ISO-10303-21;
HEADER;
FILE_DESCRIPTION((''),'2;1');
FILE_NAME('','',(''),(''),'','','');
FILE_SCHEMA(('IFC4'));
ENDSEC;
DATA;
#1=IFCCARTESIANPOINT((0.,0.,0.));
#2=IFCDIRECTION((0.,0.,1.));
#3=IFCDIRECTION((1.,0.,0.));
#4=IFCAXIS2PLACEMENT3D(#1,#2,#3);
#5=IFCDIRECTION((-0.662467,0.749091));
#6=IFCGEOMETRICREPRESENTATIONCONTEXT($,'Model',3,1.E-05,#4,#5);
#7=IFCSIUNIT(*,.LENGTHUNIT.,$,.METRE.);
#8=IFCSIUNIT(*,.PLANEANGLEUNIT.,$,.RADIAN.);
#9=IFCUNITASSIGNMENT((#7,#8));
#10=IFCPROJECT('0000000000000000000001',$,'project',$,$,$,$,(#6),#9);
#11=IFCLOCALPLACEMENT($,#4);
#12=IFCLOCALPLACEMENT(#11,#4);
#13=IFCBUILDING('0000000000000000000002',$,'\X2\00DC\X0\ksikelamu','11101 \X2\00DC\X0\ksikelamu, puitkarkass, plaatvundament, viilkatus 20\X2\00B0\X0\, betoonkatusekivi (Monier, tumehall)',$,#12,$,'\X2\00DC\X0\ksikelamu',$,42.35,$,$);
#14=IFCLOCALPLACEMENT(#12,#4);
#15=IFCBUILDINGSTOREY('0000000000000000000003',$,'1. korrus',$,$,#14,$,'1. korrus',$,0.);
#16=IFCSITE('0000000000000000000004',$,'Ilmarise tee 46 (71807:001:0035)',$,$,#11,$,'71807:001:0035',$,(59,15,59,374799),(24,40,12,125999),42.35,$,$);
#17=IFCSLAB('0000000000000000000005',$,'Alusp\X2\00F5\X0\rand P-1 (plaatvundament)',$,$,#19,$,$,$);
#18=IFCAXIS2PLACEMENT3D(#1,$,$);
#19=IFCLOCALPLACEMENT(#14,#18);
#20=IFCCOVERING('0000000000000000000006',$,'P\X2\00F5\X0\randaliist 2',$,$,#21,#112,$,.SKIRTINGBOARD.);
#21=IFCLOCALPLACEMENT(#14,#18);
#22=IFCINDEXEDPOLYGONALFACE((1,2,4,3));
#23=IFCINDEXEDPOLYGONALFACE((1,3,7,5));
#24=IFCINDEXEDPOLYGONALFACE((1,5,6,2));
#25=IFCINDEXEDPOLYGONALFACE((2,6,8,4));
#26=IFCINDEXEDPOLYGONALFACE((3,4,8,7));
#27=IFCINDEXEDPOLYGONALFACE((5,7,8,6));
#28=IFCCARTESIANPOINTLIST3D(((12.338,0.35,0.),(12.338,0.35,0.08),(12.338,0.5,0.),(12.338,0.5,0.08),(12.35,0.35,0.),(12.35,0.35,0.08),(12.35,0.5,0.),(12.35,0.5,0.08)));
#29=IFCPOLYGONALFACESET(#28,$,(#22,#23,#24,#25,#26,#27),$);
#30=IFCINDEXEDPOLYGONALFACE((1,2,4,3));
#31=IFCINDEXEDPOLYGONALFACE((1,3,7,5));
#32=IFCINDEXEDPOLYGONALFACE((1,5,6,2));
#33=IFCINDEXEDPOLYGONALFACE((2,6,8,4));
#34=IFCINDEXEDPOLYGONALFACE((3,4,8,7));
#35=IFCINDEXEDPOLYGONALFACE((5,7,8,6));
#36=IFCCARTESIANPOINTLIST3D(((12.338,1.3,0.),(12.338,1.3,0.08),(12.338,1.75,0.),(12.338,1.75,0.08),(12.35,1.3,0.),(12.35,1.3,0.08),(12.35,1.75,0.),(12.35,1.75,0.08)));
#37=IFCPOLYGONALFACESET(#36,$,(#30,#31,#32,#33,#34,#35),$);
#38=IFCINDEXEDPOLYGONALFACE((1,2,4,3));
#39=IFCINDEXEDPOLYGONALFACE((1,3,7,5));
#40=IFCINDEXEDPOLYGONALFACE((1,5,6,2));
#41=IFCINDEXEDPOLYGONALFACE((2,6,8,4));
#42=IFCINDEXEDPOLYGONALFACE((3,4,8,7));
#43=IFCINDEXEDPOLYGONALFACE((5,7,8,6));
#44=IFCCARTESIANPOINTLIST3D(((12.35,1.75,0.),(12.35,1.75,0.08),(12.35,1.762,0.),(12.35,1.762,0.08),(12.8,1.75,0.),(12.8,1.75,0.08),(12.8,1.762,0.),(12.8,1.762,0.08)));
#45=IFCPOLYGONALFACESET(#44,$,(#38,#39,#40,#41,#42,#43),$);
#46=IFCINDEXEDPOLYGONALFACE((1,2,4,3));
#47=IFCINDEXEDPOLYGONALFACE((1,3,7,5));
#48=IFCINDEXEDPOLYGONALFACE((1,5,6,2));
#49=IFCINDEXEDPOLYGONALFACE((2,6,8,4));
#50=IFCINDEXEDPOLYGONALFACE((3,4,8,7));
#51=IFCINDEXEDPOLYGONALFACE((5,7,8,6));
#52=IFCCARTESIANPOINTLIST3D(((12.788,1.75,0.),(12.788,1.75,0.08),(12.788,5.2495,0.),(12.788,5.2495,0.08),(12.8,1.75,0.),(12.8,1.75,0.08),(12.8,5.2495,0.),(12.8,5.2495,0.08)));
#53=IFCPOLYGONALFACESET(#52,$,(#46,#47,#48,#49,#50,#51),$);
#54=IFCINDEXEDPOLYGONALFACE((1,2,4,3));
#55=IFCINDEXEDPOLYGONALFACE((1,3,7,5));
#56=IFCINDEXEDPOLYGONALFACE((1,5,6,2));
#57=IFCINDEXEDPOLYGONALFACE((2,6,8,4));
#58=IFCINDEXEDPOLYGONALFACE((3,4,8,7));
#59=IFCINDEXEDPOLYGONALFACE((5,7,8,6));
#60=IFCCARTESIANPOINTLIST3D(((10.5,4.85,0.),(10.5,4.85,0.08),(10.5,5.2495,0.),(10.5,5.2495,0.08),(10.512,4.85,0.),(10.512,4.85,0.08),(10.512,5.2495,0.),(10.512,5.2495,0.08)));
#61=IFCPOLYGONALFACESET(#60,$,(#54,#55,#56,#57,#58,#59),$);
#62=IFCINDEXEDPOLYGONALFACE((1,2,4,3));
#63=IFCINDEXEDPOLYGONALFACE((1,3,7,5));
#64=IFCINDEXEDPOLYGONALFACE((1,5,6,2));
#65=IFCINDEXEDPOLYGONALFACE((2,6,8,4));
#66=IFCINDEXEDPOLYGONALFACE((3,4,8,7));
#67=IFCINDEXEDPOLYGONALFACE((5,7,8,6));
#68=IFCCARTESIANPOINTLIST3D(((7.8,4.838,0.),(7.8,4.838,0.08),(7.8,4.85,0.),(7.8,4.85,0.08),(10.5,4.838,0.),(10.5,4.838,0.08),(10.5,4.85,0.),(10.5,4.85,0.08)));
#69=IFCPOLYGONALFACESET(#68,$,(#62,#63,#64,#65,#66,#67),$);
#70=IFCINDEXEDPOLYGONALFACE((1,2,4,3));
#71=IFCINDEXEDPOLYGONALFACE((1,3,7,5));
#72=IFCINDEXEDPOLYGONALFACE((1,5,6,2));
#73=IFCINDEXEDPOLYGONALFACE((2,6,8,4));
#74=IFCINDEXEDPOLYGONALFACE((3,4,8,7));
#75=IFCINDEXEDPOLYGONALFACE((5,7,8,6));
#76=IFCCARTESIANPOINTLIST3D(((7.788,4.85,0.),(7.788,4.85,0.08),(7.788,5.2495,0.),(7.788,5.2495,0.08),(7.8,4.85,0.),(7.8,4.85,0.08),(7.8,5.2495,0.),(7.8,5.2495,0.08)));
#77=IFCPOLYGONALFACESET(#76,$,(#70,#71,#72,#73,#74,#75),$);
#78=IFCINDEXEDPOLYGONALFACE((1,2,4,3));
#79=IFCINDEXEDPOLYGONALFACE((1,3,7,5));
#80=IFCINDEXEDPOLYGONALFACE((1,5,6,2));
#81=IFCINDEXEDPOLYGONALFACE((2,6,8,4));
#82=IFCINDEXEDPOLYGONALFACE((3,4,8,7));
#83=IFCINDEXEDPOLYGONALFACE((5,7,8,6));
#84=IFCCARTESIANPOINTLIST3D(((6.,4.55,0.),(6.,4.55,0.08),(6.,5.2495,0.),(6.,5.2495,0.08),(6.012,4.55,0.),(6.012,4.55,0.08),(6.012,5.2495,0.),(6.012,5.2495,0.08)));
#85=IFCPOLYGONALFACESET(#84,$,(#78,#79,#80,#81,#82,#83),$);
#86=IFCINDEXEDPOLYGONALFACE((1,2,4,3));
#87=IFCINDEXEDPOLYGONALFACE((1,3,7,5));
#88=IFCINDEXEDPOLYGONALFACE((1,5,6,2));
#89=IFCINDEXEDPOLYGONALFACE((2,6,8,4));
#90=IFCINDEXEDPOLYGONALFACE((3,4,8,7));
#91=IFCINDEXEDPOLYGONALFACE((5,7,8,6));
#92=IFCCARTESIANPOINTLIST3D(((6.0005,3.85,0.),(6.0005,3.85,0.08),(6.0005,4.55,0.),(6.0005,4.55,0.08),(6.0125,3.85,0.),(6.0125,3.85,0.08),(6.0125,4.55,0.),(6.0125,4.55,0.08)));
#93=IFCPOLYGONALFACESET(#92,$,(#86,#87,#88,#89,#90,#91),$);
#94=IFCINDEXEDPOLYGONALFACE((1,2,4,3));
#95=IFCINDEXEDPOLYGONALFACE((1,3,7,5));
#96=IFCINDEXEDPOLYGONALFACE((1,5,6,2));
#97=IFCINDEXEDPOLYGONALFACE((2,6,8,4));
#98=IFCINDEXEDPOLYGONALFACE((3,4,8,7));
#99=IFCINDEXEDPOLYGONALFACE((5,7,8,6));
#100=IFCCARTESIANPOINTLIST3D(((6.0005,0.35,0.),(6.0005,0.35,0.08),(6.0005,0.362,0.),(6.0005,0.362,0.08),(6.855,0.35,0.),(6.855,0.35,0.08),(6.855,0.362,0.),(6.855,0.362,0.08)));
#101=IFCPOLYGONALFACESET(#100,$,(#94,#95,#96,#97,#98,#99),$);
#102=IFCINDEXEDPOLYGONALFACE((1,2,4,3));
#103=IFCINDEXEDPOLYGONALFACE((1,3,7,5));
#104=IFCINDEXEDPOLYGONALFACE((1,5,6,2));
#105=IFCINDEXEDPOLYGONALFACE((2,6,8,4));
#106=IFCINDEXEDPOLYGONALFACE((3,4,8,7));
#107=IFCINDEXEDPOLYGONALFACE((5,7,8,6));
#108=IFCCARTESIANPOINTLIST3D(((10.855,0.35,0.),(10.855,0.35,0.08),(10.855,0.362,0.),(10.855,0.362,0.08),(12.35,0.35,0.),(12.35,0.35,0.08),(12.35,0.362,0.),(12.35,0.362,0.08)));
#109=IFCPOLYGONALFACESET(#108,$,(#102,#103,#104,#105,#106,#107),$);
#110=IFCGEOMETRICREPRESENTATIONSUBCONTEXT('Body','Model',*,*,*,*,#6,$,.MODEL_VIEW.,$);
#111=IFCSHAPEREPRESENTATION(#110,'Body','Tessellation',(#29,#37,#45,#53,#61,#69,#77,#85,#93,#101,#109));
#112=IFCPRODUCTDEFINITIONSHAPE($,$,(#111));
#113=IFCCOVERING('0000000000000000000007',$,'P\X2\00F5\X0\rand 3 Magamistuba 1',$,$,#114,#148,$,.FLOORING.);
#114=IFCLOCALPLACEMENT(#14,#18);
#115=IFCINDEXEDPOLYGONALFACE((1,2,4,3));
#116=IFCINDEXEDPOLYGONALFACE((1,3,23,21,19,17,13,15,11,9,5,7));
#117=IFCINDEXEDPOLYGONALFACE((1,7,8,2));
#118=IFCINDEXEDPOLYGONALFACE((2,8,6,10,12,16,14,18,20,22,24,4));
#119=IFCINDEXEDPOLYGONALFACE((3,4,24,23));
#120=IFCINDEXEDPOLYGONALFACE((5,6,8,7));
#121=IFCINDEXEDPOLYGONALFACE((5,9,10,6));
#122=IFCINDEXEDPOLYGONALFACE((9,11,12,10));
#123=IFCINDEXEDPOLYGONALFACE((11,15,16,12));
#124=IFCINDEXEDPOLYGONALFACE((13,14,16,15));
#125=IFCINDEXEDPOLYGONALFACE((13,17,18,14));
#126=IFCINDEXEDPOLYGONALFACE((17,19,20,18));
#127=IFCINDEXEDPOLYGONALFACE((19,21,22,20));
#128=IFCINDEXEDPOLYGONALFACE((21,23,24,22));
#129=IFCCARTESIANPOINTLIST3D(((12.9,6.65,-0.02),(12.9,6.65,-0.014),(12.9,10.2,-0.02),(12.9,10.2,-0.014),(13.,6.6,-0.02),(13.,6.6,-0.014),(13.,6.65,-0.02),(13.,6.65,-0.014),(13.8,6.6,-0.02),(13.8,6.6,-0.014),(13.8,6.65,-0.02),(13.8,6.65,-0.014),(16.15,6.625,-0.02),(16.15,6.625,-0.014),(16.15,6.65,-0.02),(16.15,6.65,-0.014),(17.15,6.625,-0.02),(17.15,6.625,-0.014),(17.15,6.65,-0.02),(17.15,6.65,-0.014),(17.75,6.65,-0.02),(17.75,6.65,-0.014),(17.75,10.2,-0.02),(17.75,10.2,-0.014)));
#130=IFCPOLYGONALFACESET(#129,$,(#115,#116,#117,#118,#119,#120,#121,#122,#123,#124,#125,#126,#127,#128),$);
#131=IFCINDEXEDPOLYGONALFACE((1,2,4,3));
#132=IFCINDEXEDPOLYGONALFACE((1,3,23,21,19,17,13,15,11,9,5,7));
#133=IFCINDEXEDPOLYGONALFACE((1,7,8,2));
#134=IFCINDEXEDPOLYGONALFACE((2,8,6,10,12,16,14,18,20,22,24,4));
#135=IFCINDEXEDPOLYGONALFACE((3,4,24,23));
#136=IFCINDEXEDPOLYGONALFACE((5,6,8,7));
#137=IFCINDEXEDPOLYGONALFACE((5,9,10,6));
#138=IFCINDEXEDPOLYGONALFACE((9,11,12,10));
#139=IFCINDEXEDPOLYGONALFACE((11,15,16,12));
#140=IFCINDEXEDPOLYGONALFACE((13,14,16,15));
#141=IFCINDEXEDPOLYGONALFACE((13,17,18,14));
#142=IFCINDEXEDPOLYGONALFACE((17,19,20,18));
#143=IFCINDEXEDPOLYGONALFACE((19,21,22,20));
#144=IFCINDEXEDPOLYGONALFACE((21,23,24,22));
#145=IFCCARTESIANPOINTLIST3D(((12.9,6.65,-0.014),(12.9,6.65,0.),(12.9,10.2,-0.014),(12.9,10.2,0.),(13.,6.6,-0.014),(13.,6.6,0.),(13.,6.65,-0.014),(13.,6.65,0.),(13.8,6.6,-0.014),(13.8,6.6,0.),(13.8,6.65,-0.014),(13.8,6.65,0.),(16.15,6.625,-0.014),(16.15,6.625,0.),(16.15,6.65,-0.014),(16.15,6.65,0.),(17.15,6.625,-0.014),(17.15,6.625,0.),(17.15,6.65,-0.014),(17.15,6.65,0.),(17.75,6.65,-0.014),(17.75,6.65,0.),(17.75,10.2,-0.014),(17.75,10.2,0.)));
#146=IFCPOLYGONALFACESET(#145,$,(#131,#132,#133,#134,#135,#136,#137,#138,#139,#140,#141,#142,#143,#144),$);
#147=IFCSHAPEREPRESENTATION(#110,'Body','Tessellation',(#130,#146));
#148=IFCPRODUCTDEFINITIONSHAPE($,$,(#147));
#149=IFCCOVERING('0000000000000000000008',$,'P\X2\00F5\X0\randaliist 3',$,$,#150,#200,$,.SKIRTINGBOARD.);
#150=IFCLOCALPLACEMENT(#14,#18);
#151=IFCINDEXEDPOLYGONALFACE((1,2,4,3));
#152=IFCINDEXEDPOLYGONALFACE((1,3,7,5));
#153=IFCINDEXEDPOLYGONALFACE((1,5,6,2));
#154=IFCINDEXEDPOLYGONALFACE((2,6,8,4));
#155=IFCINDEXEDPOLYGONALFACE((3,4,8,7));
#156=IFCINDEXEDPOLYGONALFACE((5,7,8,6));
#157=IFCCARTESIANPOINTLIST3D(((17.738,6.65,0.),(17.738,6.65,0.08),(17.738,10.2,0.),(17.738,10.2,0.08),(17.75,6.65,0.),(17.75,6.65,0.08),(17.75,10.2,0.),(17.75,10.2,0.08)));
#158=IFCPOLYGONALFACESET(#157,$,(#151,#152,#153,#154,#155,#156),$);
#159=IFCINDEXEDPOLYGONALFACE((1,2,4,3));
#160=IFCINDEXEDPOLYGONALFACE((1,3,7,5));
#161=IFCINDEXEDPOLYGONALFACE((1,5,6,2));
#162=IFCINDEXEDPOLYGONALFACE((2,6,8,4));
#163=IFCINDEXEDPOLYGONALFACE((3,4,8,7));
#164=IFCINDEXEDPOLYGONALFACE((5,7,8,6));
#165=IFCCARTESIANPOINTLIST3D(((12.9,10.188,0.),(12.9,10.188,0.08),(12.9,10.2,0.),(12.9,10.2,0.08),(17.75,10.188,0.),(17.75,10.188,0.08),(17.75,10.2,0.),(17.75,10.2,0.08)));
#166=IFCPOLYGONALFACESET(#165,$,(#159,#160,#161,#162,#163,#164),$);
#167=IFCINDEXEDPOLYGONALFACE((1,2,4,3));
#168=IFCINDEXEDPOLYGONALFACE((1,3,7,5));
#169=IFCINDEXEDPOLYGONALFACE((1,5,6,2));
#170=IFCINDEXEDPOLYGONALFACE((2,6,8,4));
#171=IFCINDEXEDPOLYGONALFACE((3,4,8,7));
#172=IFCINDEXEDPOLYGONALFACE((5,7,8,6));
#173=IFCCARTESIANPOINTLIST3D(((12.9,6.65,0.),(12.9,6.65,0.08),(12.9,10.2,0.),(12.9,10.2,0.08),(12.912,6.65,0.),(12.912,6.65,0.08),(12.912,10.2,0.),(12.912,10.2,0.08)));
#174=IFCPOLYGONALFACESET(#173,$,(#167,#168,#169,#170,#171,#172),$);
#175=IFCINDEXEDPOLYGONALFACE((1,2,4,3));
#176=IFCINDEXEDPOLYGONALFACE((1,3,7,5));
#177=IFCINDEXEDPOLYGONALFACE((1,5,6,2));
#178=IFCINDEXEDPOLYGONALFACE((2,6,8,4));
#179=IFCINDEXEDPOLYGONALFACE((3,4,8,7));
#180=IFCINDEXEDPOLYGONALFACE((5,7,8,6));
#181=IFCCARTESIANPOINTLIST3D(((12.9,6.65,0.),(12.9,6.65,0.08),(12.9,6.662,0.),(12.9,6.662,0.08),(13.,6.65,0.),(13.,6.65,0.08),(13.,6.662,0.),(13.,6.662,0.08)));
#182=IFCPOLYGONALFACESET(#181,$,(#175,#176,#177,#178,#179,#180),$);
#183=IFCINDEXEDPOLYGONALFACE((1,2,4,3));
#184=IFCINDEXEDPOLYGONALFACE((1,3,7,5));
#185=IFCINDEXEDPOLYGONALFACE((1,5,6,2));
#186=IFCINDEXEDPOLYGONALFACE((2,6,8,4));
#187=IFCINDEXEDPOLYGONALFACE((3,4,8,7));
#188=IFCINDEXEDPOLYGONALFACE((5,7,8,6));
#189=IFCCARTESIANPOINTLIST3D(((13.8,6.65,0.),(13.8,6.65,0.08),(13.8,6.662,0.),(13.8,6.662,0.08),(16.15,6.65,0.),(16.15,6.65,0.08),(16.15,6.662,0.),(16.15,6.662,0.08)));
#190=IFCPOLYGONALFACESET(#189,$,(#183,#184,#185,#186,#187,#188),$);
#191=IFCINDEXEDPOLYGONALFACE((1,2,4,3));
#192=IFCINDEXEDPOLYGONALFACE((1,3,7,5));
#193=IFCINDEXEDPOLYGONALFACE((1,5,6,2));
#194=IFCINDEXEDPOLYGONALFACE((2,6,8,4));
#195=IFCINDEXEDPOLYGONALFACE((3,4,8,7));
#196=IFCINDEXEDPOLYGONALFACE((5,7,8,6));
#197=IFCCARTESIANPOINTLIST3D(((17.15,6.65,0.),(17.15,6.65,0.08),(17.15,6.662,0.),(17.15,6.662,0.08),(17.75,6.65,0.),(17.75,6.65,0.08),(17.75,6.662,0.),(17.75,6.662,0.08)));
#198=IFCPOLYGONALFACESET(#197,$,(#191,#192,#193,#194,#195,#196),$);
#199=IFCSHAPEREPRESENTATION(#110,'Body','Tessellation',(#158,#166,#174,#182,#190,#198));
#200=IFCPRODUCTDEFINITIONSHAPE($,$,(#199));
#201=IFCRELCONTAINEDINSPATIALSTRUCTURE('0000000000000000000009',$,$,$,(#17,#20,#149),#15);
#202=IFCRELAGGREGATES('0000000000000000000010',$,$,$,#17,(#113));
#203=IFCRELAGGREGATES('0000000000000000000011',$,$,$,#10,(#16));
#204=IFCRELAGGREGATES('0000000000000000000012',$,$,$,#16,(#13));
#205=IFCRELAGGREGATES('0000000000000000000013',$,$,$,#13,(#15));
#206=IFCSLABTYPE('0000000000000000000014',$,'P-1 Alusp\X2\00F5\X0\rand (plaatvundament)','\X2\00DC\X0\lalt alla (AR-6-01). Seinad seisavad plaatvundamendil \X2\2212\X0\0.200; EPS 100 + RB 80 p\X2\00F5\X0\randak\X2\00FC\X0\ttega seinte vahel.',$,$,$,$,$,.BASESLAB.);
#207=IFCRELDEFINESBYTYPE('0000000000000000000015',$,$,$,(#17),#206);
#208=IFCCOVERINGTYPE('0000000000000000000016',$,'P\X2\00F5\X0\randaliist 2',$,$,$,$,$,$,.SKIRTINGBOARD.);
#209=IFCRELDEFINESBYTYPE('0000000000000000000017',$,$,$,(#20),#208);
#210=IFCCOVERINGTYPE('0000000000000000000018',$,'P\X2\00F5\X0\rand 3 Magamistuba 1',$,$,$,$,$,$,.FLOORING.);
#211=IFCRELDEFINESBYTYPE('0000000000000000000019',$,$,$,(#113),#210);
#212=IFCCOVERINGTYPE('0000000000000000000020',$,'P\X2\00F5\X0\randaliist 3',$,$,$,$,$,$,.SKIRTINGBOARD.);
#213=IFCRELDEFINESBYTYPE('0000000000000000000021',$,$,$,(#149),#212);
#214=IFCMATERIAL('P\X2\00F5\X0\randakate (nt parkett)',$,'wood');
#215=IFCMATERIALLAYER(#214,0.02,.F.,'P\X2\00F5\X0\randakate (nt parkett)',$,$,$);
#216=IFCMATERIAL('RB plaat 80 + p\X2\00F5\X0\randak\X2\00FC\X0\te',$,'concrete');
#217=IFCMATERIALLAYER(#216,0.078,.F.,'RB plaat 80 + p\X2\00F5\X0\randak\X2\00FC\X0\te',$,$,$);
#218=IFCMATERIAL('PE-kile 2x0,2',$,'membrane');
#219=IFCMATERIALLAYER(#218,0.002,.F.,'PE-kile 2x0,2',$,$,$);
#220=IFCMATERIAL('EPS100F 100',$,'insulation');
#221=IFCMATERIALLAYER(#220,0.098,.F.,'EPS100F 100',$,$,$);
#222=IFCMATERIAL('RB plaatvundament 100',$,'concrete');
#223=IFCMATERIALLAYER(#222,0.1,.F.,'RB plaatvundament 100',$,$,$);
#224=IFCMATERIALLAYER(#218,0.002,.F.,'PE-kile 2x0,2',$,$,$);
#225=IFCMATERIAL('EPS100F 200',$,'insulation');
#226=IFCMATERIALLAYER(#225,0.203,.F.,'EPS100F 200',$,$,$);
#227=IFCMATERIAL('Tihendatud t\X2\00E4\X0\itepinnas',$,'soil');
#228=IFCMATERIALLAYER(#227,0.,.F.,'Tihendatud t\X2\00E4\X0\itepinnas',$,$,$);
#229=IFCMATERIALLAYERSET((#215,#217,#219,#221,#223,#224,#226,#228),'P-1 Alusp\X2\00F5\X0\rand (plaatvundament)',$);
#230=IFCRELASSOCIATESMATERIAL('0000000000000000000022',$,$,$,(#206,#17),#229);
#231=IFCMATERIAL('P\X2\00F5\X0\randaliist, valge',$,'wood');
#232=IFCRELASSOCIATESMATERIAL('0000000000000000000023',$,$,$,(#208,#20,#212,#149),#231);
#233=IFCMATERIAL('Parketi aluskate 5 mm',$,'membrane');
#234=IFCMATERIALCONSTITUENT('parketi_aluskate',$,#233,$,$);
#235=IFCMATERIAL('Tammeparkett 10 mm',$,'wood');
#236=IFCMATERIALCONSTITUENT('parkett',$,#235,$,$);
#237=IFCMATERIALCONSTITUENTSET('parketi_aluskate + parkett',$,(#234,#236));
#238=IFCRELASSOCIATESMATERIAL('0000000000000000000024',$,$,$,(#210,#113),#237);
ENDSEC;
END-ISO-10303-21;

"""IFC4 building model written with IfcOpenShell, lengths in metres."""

from ifc_helpers import new_model, si_unit, direction, frame, origin_with_axes, place, context, subcontext, project, spatial, indexed_curve, outline, extrude, material, layer, layer_set, layer_usage, constituent, constituent_set, type_object, element, aggregate, save


model = new_model("IFC4")

# Units and contexts
model_context = context("Model", 3, precision=1e-05, world=origin_with_axes(), true_north=direction((-0.662467, 0.749091)))
body_context = subcontext(model_context, "Body", "Model", "MODEL_VIEW")
ifc_project = project(units=[si_unit("LENGTHUNIT", "METRE"), si_unit("PLANEANGLEUNIT", "RADIAN")], contexts=[model_context])

# Site, building, storey
site_placement = place(None, origin_with_axes())
site = spatial("IfcSite", under=ifc_project, at=site_placement, Name="Ilmarise tee 46 (71807:001:0035)", LongName="71807:001:0035", RefLatitude=(59, 15, 59, 374799), RefLongitude=(24, 40, 12, 125999), RefElevation=42.35)
building_placement = place(site_placement, origin_with_axes())
building = spatial("IfcBuilding", under=site, at=building_placement, Name="Üksikelamu", Description="11101 Üksikelamu, puitkarkass, plaatvundament, viilkatus 20°, betoonkatusekivi (Monier, tumehall)", LongName="Üksikelamu", ElevationOfRefHeight=42.35)
storey_placement = place(building_placement, origin_with_axes())
storey = spatial("IfcBuildingStorey", under=building, at=storey_placement, Name="1. korrus", LongName="1. korrus", Elevation=0.0)

# Slab
ifc_material_1 = material(Name="Põrandakate (nt parkett)", Category="wood")
ifc_layer_1 = layer(ifc_material_1, 0.02, ventilated=False, Name="Põrandakate (nt parkett)")
ifc_material_2 = material(Name="RB plaat 80 + põrandaküte", Category="concrete")
ifc_layer_2 = layer(ifc_material_2, 0.078, ventilated=False, Name="RB plaat 80 + põrandaküte")
ifc_material_3 = material(Name="PE-kile 2x0,2", Category="membrane")
ifc_layer_3 = layer(ifc_material_3, 0.002, ventilated=False, Name="PE-kile 2x0,2")
ifc_material_4 = material(Name="EPS100F 100", Category="insulation")
ifc_layer_4 = layer(ifc_material_4, 0.098, ventilated=False, Name="EPS100F 100")
ifc_material_5 = material(Name="RB plaatvundament 100", Category="concrete")
ifc_layer_5 = layer(ifc_material_5, 0.1, ventilated=False, Name="RB plaatvundament 100")
ifc_layer_6 = layer(ifc_material_3, 0.002, ventilated=False, Name="PE-kile 2x0,2")
ifc_material_6 = material(Name="EPS100F 200", Category="insulation")
ifc_layer_7 = layer(ifc_material_6, 0.203, ventilated=False, Name="EPS100F 200")
ifc_material_7 = material(Name="Tihendatud täitepinnas", Category="soil")
ifc_layer_8 = layer(ifc_material_7, 0.0, ventilated=False, Name="Tihendatud täitepinnas")
ifc_layer_set_1 = layer_set([ifc_layer_1, ifc_layer_2, ifc_layer_3, ifc_layer_4, ifc_layer_5, ifc_layer_6, ifc_layer_7, ifc_layer_8], Name="P-1 Aluspõrand (plaatvundament)")
ifc_layer_usage_1 = layer_usage(ifc_layer_set_1, "AXIS3", "NEGATIVE", 0.0)
slab_type = type_object("IfcSlabType", Name="P-1 Aluspõrand (plaatvundament)", Description="Ülalt alla (AR-6-01). Seinad seisavad plaatvundamendil −0.200; EPS 100 + RB 80 põrandaküttega seinte vahel.", PredefinedType="BASESLAB", material=ifc_layer_set_1)
slab_placement = place(storey_placement, origin_with_axes())
slab = element("IfcSlab", 1, at=slab_placement, inside=storey, type_object=slab_type, material=ifc_layer_usage_1, Name="Aluspõrand P-1 (plaatvundament)")
ifc_material_8 = material(Name="Parketi aluskate 5 mm", Category="membrane")

# Coverings
ifc_material_9 = material(Name="Põrandaliist, valge", Category="wood")
covering_type_1 = type_object("IfcCoveringType", Name="Põrandaliist 2", PredefinedType="SKIRTINGBOARD", material=ifc_material_9)
covering_1_placement = place(storey_placement, origin_with_axes())
element("IfcCovering", 2, at=covering_1_placement, inside=storey, type_object=covering_type_1, material=ifc_material_9, Name="Põrandaliist 2", PredefinedType="SKIRTINGBOARD", context=body_context, shape_type="SweptSolid", body=[
    extrude(outline(indexed_curve([(12.35, 0.35), (12.338, 0.35), (12.338, 0.5), (12.35, 0.5), (12.35, 0.35)], self_intersect=False)), origin_with_axes(), (0.0, 0.0, 1.0), 0.08),
    extrude(outline(indexed_curve([(12.338, 1.75), (12.35, 1.75), (12.35, 1.3), (12.338, 1.3), (12.338, 1.75)], self_intersect=False)), origin_with_axes(), (0.0, 0.0, 1.0), 0.08),
    extrude(outline(indexed_curve([(12.35, 1.762), (12.8, 1.762), (12.8, 1.75), (12.35, 1.75), (12.35, 1.762)], self_intersect=False)), origin_with_axes(), (0.0, 0.0, 1.0), 0.08),
    extrude(outline(indexed_curve([(12.788, 1.75), (12.788, 5.2495), (12.8, 5.2495), (12.8, 1.75), (12.788, 1.75)], self_intersect=False)), origin_with_axes(), (0.0, 0.0, 1.0), 0.08),
    extrude(outline(indexed_curve([(10.512, 5.2495), (10.512, 4.85), (10.5, 4.85), (10.5, 5.2495), (10.512, 5.2495)], self_intersect=False)), origin_with_axes(), (0.0, 0.0, 1.0), 0.08),
    extrude(outline(indexed_curve([(10.5, 4.838), (7.8, 4.838), (7.8, 4.85), (10.5, 4.85), (10.5, 4.838)], self_intersect=False)), origin_with_axes(), (0.0, 0.0, 1.0), 0.08),
    extrude(outline(indexed_curve([(7.788, 4.85), (7.788, 5.2495), (7.8, 5.2495), (7.8, 4.85), (7.788, 4.85)], self_intersect=False)), origin_with_axes(), (0.0, 0.0, 1.0), 0.08),
    extrude(outline(indexed_curve([(6.012, 5.2495), (6.012, 4.55), (6.0, 4.55), (6.0, 5.2495), (6.012, 5.2495)], self_intersect=False)), origin_with_axes(), (0.0, 0.0, 1.0), 0.08),
    extrude(outline(indexed_curve([(6.0125, 4.55), (6.0125, 3.85), (6.0005, 3.85), (6.0005, 4.55), (6.0125, 4.55)], self_intersect=False)), origin_with_axes(), (0.0, 0.0, 1.0), 0.08),
    extrude(outline(indexed_curve([(6.0005, 0.35), (6.0005, 0.362), (6.855, 0.362), (6.855, 0.35), (6.0005, 0.35)], self_intersect=False)), origin_with_axes(), (0.0, 0.0, 1.0), 0.08),
    extrude(outline(indexed_curve([(12.35, 0.362), (12.35, 0.35), (10.855, 0.35), (10.855, 0.362), (12.35, 0.362)], self_intersect=False)), origin_with_axes(), (0.0, 0.0, 1.0), 0.08),
])
ifc_constituent_1 = constituent(ifc_material_8, Name="parketi_aluskate")
ifc_material_10 = material(Name="Tammeparkett 10 mm", Category="wood")
ifc_constituent_2 = constituent(ifc_material_10, Name="parkett")
ifc_constituent_set_1 = constituent_set(constituents=[ifc_constituent_1, ifc_constituent_2], Name="parketi_aluskate + parkett")
covering_type_2 = type_object("IfcCoveringType", Name="Põrand 3 Magamistuba 1", PredefinedType="FLOORING", material=ifc_constituent_set_1)
covering_2_placement = place(slab_placement, origin_with_axes())
covering_2 = element("IfcCovering", 3, at=covering_2_placement, type_object=covering_type_2, material=ifc_constituent_set_1, Name="Põrand 3 Magamistuba 1", PredefinedType="FLOORING", context=body_context, shape_type="SweptSolid", body=[
    extrude(outline(indexed_curve([(13.8, 6.6), (13.0, 6.6), (13.0, 6.65), (12.9, 6.65), (12.9, 10.2), (17.75, 10.2), (17.75, 6.65), (17.15, 6.65), (17.15, 6.625), (16.15, 6.625), (16.15, 6.65), (13.8, 6.65), (13.8, 6.6)], self_intersect=False)), frame((0.0, 0.0, -0.02), z_axis=(0.0, 0.0, 1.0), x_axis=(1.0, 0.0, 0.0)), (0.0, 0.0, 1.0), 0.006),
    extrude(outline(indexed_curve([(13.8, 6.6), (13.0, 6.6), (13.0, 6.65), (12.9, 6.65), (12.9, 10.2), (17.75, 10.2), (17.75, 6.65), (17.15, 6.65), (17.15, 6.625), (16.15, 6.625), (16.15, 6.65), (13.8, 6.65), (13.8, 6.6)], self_intersect=False)), frame((0.0, 0.0, -0.014), z_axis=(0.0, 0.0, 1.0), x_axis=(1.0, 0.0, 0.0)), (0.0, 0.0, 1.0), 0.014),
])
covering_type_3 = type_object("IfcCoveringType", Name="Põrandaliist 3", PredefinedType="SKIRTINGBOARD", material=ifc_material_9)
covering_3_placement = place(storey_placement, origin_with_axes())
element("IfcCovering", 4, at=covering_3_placement, inside=storey, type_object=covering_type_3, material=ifc_material_9, Name="Põrandaliist 3", PredefinedType="SKIRTINGBOARD", context=body_context, shape_type="SweptSolid", body=[
    extrude(outline(indexed_curve([(17.738, 6.65), (17.738, 10.2), (17.75, 10.2), (17.75, 6.65), (17.738, 6.65)], self_intersect=False)), origin_with_axes(), (0.0, 0.0, 1.0), 0.08),
    extrude(outline(indexed_curve([(17.75, 10.188), (12.9, 10.188), (12.9, 10.2), (17.75, 10.2), (17.75, 10.188)], self_intersect=False)), origin_with_axes(), (0.0, 0.0, 1.0), 0.08),
    extrude(outline(indexed_curve([(12.912, 10.2), (12.912, 6.65), (12.9, 6.65), (12.9, 10.2), (12.912, 10.2)], self_intersect=False)), origin_with_axes(), (0.0, 0.0, 1.0), 0.08),
    extrude(outline(indexed_curve([(12.9, 6.65), (12.9, 6.662), (13.0, 6.662), (13.0, 6.65), (12.9, 6.65)], self_intersect=False)), origin_with_axes(), (0.0, 0.0, 1.0), 0.08),
    extrude(outline(indexed_curve([(13.8, 6.65), (13.8, 6.662), (16.15, 6.662), (16.15, 6.65), (13.8, 6.65)], self_intersect=False)), origin_with_axes(), (0.0, 0.0, 1.0), 0.08),
    extrude(outline(indexed_curve([(17.75, 6.662), (17.75, 6.65), (17.15, 6.65), (17.15, 6.662), (17.75, 6.662)], self_intersect=False)), origin_with_axes(), (0.0, 0.0, 1.0), 0.08),
])

aggregate(slab, [covering_2])

save(model, "model.ifc")
